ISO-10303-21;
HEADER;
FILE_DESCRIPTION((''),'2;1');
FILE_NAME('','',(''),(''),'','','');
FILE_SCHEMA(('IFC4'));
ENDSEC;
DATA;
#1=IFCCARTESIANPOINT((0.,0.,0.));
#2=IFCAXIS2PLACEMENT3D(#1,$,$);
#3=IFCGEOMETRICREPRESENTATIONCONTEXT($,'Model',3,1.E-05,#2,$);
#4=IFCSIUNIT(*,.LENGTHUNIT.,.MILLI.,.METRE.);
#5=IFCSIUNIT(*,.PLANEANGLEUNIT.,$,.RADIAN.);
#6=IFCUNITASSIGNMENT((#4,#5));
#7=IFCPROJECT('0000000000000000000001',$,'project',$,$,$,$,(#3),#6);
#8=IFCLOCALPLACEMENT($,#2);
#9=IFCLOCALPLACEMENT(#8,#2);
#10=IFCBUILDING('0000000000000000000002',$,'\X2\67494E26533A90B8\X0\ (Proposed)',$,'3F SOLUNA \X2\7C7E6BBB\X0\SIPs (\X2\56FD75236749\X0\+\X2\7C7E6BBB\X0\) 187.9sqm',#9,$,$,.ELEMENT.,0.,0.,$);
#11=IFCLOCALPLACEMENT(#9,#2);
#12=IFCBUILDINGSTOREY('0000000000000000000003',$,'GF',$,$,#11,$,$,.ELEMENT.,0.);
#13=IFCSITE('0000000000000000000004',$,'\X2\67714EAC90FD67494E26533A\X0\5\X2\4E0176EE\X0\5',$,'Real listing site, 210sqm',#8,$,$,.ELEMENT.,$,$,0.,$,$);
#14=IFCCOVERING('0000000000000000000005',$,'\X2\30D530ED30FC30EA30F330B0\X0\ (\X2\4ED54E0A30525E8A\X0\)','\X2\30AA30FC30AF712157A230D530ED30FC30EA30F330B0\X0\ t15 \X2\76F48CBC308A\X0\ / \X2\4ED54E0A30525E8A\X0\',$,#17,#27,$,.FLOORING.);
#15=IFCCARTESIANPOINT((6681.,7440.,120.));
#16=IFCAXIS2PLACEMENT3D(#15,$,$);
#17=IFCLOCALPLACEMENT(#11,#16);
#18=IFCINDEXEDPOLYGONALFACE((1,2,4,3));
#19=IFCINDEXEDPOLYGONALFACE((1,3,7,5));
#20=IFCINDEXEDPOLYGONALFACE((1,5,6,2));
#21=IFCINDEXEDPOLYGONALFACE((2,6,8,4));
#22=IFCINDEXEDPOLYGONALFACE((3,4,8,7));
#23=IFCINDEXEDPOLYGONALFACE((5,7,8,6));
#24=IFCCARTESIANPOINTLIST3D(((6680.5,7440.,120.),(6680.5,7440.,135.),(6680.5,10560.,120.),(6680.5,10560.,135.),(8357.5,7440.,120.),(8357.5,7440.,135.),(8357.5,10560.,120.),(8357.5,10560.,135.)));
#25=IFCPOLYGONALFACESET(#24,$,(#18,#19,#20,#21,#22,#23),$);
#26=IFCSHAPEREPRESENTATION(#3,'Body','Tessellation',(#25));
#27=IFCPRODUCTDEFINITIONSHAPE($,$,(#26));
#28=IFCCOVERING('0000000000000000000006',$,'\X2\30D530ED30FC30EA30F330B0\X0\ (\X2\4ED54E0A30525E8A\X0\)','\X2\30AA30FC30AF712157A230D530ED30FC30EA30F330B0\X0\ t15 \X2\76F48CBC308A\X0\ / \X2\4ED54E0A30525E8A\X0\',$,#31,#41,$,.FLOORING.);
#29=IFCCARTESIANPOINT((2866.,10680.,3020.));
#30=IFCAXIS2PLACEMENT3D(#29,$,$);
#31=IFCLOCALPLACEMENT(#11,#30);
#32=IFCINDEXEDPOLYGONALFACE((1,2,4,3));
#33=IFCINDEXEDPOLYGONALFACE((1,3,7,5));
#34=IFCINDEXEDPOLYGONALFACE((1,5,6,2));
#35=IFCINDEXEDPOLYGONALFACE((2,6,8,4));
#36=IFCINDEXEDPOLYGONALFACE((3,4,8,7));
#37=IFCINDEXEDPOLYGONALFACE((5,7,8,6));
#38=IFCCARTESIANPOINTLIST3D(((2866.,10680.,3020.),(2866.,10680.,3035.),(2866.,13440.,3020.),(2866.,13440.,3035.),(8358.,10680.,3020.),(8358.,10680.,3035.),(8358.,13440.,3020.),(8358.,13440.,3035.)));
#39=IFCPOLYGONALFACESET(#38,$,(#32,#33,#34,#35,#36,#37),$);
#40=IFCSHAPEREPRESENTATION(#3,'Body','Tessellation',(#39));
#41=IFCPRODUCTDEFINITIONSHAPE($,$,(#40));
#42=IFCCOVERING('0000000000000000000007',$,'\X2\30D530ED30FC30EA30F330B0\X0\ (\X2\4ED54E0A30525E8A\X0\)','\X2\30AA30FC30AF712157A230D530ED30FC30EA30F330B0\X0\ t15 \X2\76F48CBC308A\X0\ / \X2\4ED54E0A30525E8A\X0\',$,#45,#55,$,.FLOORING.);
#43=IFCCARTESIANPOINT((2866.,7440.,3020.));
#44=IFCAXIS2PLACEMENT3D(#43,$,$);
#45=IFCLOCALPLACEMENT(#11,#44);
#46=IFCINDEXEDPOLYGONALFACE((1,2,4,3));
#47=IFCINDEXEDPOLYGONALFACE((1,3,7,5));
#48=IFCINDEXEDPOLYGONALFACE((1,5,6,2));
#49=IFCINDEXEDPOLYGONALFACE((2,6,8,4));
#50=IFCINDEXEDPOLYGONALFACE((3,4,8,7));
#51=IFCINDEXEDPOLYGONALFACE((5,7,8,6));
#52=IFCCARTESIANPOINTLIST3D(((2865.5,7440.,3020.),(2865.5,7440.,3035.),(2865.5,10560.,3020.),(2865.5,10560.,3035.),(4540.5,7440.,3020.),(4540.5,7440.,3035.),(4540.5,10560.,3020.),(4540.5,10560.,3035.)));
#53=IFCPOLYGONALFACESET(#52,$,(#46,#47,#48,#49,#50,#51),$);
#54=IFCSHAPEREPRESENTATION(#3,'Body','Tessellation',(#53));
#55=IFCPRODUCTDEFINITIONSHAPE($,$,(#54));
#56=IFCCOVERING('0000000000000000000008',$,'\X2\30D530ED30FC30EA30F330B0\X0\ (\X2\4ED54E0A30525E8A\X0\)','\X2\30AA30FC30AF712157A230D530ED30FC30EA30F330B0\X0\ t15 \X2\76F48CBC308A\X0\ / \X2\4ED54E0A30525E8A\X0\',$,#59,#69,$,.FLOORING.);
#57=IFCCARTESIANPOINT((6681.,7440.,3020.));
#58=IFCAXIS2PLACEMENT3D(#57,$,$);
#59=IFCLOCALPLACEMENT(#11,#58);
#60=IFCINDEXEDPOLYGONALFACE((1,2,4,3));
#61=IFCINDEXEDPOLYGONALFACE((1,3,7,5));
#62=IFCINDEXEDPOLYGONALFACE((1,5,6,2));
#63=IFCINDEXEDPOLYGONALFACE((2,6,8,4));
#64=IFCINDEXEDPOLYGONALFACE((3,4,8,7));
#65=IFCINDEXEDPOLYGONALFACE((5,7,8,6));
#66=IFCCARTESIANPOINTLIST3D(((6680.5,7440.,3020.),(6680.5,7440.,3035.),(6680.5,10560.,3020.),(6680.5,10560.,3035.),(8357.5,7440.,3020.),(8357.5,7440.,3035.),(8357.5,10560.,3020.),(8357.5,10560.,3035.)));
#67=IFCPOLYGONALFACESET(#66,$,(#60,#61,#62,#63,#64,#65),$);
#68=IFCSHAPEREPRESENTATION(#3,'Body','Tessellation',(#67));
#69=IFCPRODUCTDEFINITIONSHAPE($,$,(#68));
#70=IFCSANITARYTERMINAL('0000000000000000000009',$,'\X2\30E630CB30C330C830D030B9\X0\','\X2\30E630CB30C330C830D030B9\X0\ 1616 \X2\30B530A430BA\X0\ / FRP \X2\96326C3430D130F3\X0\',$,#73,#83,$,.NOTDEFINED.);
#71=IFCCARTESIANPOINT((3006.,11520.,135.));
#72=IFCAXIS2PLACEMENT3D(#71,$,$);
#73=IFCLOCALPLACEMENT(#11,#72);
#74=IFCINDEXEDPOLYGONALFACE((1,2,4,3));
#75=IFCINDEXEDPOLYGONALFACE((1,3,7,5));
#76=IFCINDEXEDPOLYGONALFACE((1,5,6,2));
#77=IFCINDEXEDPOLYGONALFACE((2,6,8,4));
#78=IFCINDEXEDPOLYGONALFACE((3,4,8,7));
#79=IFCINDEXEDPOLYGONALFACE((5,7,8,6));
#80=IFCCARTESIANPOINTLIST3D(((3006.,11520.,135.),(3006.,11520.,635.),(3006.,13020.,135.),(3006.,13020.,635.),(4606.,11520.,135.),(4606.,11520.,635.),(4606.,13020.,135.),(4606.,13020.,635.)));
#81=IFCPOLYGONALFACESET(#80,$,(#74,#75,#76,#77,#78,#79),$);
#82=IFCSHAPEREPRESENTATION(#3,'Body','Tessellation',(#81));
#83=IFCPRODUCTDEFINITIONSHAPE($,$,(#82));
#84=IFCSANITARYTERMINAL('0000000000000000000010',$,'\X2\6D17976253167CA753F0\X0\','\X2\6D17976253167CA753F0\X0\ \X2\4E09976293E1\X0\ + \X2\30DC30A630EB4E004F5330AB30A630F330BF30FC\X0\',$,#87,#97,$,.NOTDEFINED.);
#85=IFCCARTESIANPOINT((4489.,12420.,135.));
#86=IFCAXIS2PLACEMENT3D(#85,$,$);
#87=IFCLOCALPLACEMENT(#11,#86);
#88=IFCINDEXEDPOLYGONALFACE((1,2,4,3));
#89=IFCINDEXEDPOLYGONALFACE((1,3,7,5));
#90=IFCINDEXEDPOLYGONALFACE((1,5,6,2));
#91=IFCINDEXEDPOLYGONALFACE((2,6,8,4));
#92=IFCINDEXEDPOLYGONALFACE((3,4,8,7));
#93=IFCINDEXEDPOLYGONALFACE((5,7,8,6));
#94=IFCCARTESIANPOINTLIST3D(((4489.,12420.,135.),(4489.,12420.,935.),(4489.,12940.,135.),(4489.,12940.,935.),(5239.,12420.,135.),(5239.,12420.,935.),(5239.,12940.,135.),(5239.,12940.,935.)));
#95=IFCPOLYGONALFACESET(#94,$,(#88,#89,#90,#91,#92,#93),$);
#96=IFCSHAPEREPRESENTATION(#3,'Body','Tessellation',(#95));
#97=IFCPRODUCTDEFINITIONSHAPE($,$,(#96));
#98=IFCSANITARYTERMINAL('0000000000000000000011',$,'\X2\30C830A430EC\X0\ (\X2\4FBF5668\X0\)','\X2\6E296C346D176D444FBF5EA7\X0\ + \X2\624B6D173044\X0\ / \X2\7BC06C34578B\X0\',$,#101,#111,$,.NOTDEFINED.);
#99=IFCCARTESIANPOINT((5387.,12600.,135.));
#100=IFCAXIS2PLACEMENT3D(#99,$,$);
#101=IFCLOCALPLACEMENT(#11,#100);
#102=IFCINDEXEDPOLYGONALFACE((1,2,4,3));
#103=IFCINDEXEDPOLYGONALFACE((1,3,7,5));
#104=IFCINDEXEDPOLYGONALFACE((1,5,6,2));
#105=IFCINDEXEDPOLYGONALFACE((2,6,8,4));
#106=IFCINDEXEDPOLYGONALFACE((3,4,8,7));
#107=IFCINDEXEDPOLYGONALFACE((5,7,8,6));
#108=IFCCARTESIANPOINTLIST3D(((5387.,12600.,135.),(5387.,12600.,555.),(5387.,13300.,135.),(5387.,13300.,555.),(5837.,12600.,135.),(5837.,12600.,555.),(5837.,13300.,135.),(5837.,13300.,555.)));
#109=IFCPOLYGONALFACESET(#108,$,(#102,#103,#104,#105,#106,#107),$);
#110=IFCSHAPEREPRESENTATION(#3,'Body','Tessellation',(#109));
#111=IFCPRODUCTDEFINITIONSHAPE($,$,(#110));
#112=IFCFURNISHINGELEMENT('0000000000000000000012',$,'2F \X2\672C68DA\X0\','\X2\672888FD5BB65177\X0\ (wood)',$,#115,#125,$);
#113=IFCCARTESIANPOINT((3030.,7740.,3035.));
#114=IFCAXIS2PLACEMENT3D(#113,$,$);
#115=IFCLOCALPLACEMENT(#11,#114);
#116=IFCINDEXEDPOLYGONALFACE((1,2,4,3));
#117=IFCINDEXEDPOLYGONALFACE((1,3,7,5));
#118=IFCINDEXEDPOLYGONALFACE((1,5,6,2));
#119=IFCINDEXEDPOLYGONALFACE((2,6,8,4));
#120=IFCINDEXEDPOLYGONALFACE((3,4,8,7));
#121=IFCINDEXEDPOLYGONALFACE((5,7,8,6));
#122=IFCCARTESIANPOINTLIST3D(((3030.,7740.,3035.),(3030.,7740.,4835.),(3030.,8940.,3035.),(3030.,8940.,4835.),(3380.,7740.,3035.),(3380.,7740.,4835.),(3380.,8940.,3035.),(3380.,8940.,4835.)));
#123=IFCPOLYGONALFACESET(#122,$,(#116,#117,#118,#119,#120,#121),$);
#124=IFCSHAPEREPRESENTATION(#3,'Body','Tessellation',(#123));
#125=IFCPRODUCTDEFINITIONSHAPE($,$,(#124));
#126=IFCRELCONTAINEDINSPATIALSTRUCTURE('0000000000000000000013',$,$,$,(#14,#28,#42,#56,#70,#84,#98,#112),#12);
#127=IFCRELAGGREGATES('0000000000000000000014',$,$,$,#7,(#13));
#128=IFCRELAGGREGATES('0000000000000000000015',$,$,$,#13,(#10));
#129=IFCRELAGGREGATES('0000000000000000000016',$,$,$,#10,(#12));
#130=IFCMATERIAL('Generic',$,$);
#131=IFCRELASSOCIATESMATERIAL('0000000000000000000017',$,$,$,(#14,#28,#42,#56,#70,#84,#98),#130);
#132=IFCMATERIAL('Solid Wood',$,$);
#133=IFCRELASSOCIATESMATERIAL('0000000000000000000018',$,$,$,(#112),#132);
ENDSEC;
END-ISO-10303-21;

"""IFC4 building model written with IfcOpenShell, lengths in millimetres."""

from ifc_helpers import new_model, si_unit, frame, frame_2d, origin, place, context, project, spatial, rectangle, extrude, material, element, save


model = new_model("IFC4")

# Units and contexts
model_context = context("Model", 3, precision=1e-05, world=origin())
ifc_project = project(units=[si_unit("LENGTHUNIT", "METRE", prefix="MILLI"), si_unit("PLANEANGLEUNIT", "RADIAN")], contexts=[model_context])

# Site, building, storey
site_placement = place(None, origin())
site = spatial("IfcSite", under=ifc_project, at=site_placement, Name="東京都杉並区5丁目5", ObjectType="Real listing site, 210sqm", CompositionType="ELEMENT", RefElevation=0.0)
building_placement = place(site_placement, origin())
building = spatial("IfcBuilding", under=site, at=building_placement, Name="杉並区邸 (Proposed)", ObjectType="3F SOLUNA 籾殻SIPs (国産杉+籾殻) 187.9sqm", CompositionType="ELEMENT", ElevationOfRefHeight=0.0, ElevationOfTerrain=0.0)
storey_placement = place(building_placement, origin())
storey = spatial("IfcBuildingStorey", under=building, at=storey_placement, Name="GF", CompositionType="ELEMENT", Elevation=0.0)

# Shared definitions
ifc_material_1 = material(Name="Solid Wood")

# Coverings
ifc_material_2 = material(Name="Generic")
covering_1_placement = place(storey_placement, frame((6681.0, 7440.0, 120.0)))
element("IfcCovering", 1, at=covering_1_placement, inside=storey, material=ifc_material_2, Name="フローリング (仕上げ床)", Description="オーク無垢フローリング t15 直貼り / 仕上げ床", PredefinedType="FLOORING", context=model_context, shape_type="SweptSolid", body=[
    extrude(rectangle(XDim=1677.0, YDim=3120.0, at=frame_2d((838.0, 1560.0))), frame((6681.0, 7440.0, 120.0)), (0.0, 0.0, 1.0), 15.0),
])
covering_2_placement = place(storey_placement, frame((2866.0, 10680.0, 3020.0)))
element("IfcCovering", 2, at=covering_2_placement, inside=storey, material=ifc_material_2, Name="フローリング (仕上げ床)", Description="オーク無垢フローリング t15 直貼り / 仕上げ床", PredefinedType="FLOORING", context=model_context, shape_type="SweptSolid", body=[
    extrude(rectangle(XDim=5492.0, YDim=2760.0, at=frame_2d((2746.0, 1380.0))), frame((2866.0, 10680.0, 3020.0)), (0.0, 0.0, 1.0), 15.0),
])
covering_3_placement = place(storey_placement, frame((2866.0, 7440.0, 3020.0)))
element("IfcCovering", 3, at=covering_3_placement, inside=storey, material=ifc_material_2, Name="フローリング (仕上げ床)", Description="オーク無垢フローリング t15 直貼り / 仕上げ床", PredefinedType="FLOORING", context=model_context, shape_type="SweptSolid", body=[
    extrude(rectangle(XDim=1675.0, YDim=3120.0, at=frame_2d((837.0, 1560.0))), frame((2866.0, 7440.0, 3020.0)), (0.0, 0.0, 1.0), 15.0),
])
covering_4_placement = place(storey_placement, frame((6681.0, 7440.0, 3020.0)))
element("IfcCovering", 4, at=covering_4_placement, inside=storey, material=ifc_material_2, Name="フローリング (仕上げ床)", Description="オーク無垢フローリング t15 直貼り / 仕上げ床", PredefinedType="FLOORING", context=model_context, shape_type="SweptSolid", body=[
    extrude(rectangle(XDim=1677.0, YDim=3120.0, at=frame_2d((838.0, 1560.0))), frame((6681.0, 7440.0, 3020.0)), (0.0, 0.0, 1.0), 15.0),
])

# Sanitary terminals
sanitary_terminal_1_placement = place(storey_placement, frame((3006.0, 11520.0, 135.0)))
element("IfcSanitaryTerminal", 5, at=sanitary_terminal_1_placement, inside=storey, material=ifc_material_2, Name="ユニットバス", Description="ユニットバス 1616 サイズ / FRP 防水パン", PredefinedType="NOTDEFINED", context=model_context, shape_type="SweptSolid", body=[
    extrude(rectangle(XDim=1600.0, YDim=1500.0, at=frame_2d((800.0, 750.0))), frame((3006.0, 11520.0, 135.0)), (0.0, 0.0, 1.0), 500.0),
])
sanitary_terminal_2_placement = place(storey_placement, frame((4489.0, 12420.0, 135.0)))
element("IfcSanitaryTerminal", 6, at=sanitary_terminal_2_placement, inside=storey, material=ifc_material_2, Name="洗面化粧台", Description="洗面化粧台 三面鏡 + ボウル一体カウンター", PredefinedType="NOTDEFINED", context=model_context, shape_type="SweptSolid", body=[
    extrude(rectangle(XDim=750.0, YDim=520.0, at=frame_2d((375.0, 260.0))), frame((4489.0, 12420.0, 135.0)), (0.0, 0.0, 1.0), 800.0),
])
sanitary_terminal_3_placement = place(storey_placement, frame((5387.0, 12600.0, 135.0)))
element("IfcSanitaryTerminal", 7, at=sanitary_terminal_3_placement, inside=storey, material=ifc_material_2, Name="トイレ (便器)", Description="温水洗浄便座 + 手洗い / 節水型", PredefinedType="NOTDEFINED", context=model_context, shape_type="SweptSolid", body=[
    extrude(rectangle(XDim=450.0, YDim=700.0, at=frame_2d((225.0, 350.0))), frame((5387.0, 12600.0, 135.0)), (0.0, 0.0, 1.0), 420.0),
])

# Furnishing element
furnishing_placement = place(storey_placement, frame((3030.0, 7740.0, 3035.0)))
element("IfcFurnishingElement", 8, at=furnishing_placement, inside=storey, material=ifc_material_1, Name="2F 本棚", Description="木製家具 (wood)", context=model_context, shape_type="SweptSolid", body=[
    extrude(rectangle(XDim=350.0, YDim=1200.0, at=frame_2d((175.0, 600.0))), frame((3030.0, 7740.0, 3035.0)), (0.0, 0.0, 1.0), 1800.0),
])

save(model, "model.ifc")
